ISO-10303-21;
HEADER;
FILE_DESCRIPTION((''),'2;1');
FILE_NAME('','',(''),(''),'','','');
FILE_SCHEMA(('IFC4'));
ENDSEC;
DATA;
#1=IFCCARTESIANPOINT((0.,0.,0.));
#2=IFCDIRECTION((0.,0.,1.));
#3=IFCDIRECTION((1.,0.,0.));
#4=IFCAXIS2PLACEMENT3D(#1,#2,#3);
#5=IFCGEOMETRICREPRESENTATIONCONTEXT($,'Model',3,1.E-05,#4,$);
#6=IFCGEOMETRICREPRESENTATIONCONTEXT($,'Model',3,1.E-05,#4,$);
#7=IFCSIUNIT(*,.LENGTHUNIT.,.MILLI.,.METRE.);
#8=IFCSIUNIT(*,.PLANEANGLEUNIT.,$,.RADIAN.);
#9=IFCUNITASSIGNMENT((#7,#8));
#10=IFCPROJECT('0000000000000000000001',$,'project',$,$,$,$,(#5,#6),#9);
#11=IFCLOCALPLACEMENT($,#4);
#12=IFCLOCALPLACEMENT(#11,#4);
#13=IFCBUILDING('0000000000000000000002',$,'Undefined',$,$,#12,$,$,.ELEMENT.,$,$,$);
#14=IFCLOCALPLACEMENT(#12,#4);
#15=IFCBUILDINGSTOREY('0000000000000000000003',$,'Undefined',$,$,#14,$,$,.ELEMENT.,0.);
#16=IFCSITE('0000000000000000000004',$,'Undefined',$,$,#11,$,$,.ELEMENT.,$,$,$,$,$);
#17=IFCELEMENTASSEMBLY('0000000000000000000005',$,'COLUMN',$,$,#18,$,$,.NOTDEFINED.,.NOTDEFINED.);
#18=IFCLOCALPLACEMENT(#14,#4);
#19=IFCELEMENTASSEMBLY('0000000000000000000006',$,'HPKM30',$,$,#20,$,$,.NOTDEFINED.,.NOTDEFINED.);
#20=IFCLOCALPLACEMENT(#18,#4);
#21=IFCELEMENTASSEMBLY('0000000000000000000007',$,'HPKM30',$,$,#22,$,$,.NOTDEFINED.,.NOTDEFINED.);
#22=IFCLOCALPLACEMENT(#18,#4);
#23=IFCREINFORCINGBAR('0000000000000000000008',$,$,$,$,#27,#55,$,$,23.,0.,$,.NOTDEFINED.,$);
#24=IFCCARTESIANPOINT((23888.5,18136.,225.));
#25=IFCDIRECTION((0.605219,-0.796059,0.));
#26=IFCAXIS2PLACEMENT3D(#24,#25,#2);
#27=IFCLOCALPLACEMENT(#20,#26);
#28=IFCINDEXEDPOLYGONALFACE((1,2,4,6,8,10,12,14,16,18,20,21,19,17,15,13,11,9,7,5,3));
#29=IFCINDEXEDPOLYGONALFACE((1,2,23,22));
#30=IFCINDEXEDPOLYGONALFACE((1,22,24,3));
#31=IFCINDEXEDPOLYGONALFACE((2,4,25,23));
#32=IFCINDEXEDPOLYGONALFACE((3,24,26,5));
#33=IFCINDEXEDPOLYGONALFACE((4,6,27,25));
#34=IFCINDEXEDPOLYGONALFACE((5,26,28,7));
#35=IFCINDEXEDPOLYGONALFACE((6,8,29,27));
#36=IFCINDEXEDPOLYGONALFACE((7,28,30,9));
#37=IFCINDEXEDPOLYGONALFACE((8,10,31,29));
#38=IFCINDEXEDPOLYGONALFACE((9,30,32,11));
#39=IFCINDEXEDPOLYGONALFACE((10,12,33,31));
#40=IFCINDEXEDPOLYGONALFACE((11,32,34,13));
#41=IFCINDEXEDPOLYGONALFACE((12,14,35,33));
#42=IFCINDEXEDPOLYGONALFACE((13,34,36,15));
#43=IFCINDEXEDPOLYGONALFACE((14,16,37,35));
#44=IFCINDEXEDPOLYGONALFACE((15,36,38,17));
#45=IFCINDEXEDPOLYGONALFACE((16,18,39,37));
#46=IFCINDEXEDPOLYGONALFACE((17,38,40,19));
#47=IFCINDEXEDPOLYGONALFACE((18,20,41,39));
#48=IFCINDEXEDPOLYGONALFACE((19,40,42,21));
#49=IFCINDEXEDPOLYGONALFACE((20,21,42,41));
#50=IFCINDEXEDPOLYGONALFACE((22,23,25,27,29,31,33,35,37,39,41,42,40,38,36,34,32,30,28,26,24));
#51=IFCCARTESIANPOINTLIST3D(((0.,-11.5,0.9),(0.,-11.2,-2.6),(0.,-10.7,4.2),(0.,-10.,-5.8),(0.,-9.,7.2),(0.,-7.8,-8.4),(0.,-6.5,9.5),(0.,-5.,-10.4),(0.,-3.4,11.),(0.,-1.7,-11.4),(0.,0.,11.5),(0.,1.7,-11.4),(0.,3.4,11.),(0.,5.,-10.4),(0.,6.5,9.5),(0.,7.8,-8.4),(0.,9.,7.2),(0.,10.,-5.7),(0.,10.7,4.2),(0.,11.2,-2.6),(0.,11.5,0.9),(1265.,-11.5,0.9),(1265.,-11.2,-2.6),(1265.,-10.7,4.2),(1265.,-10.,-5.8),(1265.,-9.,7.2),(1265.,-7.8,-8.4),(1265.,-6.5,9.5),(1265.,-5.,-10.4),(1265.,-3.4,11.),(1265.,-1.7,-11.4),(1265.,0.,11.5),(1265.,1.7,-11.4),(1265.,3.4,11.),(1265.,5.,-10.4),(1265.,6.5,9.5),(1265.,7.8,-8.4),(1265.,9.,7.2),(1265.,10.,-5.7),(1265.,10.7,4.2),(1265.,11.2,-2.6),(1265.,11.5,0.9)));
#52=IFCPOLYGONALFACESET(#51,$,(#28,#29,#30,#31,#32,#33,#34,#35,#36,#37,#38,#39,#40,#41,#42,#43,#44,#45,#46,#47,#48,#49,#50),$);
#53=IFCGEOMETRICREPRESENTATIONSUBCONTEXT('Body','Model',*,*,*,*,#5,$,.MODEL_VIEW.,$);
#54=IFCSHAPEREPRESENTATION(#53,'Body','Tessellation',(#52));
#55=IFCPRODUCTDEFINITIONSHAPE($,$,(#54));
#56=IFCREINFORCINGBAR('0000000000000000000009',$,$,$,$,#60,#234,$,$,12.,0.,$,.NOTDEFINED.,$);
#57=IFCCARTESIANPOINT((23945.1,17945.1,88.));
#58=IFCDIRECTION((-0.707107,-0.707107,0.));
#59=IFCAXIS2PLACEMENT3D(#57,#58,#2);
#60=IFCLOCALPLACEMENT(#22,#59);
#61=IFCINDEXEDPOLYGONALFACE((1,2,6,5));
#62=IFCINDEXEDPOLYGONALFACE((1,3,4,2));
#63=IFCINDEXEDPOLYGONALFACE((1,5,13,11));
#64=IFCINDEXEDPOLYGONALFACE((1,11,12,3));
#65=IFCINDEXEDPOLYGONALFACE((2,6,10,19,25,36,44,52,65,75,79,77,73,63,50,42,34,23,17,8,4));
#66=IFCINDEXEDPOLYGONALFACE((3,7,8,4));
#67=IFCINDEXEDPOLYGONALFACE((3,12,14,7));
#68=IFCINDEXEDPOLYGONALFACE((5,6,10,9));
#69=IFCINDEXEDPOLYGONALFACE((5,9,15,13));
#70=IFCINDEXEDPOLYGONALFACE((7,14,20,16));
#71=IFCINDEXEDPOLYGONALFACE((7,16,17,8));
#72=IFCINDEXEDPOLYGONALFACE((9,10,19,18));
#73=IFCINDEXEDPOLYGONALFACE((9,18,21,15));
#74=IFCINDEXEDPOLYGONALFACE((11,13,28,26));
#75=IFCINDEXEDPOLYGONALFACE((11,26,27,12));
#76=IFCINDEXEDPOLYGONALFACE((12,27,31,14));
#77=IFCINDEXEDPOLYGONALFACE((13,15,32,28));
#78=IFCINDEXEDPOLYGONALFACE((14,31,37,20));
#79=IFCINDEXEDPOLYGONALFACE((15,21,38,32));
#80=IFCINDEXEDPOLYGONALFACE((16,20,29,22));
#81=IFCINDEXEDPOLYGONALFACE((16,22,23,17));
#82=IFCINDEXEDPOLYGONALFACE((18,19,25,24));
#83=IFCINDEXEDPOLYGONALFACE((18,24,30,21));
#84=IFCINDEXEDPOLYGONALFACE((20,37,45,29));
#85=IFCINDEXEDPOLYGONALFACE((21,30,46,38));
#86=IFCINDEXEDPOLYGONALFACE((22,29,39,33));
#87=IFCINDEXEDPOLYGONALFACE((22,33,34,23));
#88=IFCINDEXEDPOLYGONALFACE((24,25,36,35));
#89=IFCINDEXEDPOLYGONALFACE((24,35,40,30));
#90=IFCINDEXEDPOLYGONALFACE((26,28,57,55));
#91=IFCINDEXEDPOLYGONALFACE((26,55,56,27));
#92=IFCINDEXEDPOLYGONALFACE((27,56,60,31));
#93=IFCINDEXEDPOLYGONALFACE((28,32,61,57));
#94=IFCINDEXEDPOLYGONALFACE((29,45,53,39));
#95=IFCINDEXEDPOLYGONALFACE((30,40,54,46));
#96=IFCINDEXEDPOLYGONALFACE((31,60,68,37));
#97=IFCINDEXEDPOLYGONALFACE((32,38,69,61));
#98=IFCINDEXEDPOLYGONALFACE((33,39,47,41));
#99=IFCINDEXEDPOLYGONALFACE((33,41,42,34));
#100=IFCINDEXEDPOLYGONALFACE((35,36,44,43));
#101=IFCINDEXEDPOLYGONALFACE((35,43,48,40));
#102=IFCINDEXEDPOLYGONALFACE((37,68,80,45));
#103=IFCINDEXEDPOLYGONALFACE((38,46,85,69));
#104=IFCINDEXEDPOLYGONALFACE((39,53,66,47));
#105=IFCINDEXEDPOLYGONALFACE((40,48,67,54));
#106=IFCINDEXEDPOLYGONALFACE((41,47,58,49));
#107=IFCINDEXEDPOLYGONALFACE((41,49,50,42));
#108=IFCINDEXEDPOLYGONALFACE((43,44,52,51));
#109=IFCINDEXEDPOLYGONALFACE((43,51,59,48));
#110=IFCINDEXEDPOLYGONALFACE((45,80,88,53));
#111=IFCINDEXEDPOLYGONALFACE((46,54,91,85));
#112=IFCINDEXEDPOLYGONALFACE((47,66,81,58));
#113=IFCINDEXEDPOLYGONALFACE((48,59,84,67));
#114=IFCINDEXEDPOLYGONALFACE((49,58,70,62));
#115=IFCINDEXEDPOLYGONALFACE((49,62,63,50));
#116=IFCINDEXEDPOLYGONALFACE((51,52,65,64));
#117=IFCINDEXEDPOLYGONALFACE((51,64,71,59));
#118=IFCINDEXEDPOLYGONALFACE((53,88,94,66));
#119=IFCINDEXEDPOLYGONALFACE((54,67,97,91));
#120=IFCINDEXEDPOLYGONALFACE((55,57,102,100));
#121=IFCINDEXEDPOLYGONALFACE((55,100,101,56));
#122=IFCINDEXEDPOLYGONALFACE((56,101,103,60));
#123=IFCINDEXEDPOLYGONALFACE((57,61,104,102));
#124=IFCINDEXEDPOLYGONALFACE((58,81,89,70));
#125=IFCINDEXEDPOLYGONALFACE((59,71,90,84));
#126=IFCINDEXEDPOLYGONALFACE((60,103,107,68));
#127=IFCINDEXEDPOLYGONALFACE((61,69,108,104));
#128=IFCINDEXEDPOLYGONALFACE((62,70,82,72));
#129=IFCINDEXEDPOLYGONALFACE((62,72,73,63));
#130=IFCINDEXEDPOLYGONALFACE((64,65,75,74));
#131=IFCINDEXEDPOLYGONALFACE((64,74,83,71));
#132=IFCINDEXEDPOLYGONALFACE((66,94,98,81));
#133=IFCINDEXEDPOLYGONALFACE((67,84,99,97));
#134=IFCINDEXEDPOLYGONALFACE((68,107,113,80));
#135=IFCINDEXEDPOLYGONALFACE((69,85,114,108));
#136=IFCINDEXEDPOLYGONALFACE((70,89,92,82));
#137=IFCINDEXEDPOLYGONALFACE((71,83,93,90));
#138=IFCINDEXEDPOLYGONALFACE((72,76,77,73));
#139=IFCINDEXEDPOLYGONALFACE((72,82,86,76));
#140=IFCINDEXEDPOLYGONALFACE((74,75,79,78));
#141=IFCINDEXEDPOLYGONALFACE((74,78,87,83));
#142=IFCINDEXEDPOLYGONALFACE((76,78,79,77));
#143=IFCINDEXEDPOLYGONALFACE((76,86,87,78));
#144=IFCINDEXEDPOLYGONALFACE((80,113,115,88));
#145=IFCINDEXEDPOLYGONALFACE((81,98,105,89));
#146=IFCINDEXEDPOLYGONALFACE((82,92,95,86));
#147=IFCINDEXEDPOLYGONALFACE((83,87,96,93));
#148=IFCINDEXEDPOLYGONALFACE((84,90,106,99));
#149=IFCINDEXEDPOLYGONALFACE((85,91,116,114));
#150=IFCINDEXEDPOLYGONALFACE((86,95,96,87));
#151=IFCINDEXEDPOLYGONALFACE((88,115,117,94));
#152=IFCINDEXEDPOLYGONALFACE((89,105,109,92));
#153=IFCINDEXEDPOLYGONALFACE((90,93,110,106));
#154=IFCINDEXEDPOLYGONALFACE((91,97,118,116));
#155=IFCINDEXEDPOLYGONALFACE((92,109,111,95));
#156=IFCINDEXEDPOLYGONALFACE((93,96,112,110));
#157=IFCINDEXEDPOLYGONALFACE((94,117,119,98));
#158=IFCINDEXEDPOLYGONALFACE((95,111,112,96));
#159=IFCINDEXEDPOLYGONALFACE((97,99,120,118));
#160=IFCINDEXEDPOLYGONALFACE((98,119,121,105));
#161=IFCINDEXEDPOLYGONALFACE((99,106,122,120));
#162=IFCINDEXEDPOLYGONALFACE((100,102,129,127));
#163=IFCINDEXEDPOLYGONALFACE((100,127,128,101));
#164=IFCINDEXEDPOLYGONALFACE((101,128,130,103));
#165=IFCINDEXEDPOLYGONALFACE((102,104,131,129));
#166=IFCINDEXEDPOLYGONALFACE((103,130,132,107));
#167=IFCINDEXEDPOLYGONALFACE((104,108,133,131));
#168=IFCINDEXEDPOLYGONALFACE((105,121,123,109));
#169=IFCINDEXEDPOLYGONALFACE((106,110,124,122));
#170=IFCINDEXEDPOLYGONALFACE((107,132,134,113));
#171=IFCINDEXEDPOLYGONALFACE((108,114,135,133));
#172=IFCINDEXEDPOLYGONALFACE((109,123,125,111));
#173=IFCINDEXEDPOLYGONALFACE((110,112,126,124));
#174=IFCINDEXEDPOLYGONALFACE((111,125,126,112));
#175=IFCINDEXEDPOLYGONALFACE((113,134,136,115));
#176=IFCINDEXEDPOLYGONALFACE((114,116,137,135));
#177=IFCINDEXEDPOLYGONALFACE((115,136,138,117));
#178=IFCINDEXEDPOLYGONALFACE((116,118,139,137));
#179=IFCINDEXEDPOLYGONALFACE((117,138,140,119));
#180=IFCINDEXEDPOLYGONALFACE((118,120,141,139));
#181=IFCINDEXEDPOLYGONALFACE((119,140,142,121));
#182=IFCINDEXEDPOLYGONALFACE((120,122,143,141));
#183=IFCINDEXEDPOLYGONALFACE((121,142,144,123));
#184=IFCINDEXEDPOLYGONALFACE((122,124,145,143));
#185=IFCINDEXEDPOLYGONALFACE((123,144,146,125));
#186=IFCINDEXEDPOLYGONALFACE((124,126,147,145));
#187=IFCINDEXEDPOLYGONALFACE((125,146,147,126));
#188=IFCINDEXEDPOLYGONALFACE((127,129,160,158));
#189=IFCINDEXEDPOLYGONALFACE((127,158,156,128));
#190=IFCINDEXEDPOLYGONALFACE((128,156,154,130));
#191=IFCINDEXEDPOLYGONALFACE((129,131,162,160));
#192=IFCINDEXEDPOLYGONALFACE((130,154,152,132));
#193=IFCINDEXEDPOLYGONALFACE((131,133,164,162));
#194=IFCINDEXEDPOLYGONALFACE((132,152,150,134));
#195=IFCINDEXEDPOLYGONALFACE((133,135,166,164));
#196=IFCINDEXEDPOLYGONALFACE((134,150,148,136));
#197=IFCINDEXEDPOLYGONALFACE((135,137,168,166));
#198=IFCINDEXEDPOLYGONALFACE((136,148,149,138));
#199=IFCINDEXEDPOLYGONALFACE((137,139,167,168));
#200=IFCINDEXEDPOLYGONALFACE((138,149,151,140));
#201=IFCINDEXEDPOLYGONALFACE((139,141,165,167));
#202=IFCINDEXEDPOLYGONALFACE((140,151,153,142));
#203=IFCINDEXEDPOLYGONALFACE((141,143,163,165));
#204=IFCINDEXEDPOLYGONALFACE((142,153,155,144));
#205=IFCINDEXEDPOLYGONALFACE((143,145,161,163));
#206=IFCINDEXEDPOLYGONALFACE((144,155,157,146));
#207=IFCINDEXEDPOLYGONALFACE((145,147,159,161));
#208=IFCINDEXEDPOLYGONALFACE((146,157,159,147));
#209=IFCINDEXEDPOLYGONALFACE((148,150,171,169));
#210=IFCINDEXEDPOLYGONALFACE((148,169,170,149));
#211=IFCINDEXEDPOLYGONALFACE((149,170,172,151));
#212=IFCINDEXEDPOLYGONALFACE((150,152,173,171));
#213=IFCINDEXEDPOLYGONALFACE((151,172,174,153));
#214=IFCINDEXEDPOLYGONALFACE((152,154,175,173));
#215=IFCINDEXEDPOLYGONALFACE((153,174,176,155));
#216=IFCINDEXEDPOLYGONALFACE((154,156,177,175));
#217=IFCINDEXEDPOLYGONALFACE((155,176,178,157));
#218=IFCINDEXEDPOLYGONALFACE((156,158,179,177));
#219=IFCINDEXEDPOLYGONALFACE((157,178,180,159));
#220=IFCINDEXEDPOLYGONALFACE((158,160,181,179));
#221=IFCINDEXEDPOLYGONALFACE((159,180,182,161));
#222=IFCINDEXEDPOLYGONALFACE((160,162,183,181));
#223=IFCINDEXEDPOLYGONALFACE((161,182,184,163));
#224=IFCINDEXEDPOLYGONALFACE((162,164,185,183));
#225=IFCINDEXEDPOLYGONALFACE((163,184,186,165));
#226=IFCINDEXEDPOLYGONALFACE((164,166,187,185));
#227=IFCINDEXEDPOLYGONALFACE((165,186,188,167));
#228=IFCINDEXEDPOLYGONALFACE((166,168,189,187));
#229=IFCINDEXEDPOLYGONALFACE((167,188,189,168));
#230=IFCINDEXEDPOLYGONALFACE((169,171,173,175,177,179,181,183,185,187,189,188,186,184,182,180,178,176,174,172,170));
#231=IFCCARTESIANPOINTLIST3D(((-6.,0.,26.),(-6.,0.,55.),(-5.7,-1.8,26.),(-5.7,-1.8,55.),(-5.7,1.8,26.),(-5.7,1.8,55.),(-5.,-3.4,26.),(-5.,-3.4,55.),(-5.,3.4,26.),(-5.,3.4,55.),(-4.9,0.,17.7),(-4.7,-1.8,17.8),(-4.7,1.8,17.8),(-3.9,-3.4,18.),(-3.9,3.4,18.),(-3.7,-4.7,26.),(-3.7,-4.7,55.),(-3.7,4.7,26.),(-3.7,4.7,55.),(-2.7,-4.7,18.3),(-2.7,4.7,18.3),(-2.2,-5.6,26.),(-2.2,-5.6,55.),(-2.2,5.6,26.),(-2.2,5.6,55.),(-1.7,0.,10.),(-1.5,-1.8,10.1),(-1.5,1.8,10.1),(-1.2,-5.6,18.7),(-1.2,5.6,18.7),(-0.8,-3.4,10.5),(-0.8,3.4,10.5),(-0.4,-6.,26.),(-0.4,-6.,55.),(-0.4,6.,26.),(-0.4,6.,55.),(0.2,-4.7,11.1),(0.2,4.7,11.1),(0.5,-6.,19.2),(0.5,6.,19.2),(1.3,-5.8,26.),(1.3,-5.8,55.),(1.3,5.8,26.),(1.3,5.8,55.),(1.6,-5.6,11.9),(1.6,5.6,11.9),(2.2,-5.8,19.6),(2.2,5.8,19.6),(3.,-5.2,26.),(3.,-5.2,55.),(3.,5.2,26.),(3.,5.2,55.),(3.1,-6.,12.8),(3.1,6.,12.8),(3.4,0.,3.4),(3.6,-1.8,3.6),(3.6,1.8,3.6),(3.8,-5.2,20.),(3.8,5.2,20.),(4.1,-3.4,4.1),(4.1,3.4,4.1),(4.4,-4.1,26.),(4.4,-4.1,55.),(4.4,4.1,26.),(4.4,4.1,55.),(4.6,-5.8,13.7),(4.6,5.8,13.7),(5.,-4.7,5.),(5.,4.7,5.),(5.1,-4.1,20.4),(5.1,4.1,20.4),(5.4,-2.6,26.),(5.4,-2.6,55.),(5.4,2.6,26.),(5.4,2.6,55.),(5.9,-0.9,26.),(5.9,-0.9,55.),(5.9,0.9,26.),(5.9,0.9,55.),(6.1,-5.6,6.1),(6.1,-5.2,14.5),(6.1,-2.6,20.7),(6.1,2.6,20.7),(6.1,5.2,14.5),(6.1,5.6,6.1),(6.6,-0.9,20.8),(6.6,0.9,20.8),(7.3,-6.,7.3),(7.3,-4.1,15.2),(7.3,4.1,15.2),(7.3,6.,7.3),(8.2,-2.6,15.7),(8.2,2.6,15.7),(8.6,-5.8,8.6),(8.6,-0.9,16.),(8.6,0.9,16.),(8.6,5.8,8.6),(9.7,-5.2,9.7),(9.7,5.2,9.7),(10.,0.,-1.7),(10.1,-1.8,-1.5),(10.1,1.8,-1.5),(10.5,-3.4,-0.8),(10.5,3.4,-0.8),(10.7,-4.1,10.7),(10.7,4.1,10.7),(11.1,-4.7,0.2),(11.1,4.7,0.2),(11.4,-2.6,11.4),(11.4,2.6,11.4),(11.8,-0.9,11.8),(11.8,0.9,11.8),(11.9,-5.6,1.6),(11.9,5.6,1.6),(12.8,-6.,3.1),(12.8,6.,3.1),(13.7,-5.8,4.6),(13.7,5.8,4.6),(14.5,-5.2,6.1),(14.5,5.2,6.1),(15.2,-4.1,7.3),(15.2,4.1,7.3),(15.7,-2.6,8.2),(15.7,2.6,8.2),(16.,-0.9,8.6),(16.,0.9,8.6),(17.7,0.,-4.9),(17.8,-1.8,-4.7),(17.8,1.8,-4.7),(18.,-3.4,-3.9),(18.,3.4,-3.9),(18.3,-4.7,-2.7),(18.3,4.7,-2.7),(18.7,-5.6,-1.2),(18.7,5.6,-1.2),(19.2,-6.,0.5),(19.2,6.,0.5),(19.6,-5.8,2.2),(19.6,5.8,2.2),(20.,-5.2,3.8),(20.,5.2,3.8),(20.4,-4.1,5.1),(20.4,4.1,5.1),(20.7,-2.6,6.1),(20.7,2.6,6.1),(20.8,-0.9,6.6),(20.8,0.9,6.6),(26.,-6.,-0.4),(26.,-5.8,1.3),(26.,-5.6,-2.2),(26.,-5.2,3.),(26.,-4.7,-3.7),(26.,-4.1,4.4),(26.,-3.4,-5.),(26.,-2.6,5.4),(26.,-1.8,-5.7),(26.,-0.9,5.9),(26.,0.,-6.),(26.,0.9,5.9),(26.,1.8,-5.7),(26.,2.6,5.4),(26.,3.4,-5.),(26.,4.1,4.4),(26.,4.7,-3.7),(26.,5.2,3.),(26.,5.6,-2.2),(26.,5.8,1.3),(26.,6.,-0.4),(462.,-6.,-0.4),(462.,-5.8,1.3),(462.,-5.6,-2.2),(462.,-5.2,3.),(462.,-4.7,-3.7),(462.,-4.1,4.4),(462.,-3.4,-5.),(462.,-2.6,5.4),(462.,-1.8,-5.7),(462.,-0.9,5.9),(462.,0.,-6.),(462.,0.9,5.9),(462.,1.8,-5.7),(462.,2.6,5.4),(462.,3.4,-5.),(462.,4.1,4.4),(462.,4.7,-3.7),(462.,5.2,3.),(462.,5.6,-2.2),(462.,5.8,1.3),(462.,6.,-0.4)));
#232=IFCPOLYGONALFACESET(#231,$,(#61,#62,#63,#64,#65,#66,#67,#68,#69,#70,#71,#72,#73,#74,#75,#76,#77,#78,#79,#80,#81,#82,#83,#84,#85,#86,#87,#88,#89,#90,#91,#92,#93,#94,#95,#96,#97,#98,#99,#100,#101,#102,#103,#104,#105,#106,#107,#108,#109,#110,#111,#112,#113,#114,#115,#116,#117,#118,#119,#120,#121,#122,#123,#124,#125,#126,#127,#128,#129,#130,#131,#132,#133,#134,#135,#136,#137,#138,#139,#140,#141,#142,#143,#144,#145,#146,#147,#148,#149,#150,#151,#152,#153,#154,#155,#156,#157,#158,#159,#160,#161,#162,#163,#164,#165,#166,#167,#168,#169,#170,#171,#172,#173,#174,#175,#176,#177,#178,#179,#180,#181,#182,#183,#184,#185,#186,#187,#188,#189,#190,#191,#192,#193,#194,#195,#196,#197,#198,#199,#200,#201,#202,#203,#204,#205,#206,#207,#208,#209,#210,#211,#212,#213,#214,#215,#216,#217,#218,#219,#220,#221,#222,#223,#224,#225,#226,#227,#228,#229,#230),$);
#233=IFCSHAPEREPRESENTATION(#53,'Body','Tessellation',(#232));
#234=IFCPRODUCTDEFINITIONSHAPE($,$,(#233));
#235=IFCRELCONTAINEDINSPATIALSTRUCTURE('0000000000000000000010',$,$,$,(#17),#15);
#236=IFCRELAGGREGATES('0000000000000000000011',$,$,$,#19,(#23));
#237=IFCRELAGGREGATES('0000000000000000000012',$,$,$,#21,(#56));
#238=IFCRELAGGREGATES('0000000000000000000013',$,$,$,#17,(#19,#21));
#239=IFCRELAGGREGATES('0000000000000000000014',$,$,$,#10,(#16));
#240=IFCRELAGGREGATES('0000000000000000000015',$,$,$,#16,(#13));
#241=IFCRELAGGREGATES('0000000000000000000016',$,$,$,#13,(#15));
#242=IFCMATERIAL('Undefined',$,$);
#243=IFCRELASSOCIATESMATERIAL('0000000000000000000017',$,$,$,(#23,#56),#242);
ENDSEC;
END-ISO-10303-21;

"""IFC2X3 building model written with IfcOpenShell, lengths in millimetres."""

from ifc_helpers import new_model, entity, si_unit, frame, origin_with_axes, place, context, subcontext, project, spatial, source, transform, mapped, material, element, aggregate, save


model = new_model("IFC2X3")

# Units and contexts
model_context_1 = context("Model", 3, precision=1e-05, world=origin_with_axes())
model_context_2 = context("Model", 3, precision=1e-05, world=origin_with_axes())
body_context = subcontext(model_context_1, "Body", "Model", "MODEL_VIEW")
ifc_project = project(units=[si_unit("LENGTHUNIT", "METRE", prefix="MILLI"), si_unit("PLANEANGLEUNIT", "RADIAN")], contexts=[model_context_1, model_context_2])

# Site, building, storey
site_placement = place(None, origin_with_axes())
site = spatial("IfcSite", under=ifc_project, at=site_placement, Name="Undefined", CompositionType="ELEMENT")
building_placement = place(site_placement, origin_with_axes())
building = spatial("IfcBuilding", under=site, at=building_placement, Name="Undefined", CompositionType="ELEMENT")
storey_placement = place(building_placement, origin_with_axes())
storey = spatial("IfcBuildingStorey", under=building, at=storey_placement, Name="Undefined", CompositionType="ELEMENT", Elevation=0.0)

# Element assemblies
assembly_1_placement = place(storey_placement, origin_with_axes())
assembly_1 = element("IfcElementAssembly", 1, at=assembly_1_placement, inside=storey, Name="COLUMN", AssemblyPlace="NOTDEFINED", PredefinedType="NOTDEFINED")
assembly_2_placement = place(assembly_1_placement, origin_with_axes())
assembly_2 = element("IfcElementAssembly", 2, at=assembly_2_placement, Name="HPKM30", AssemblyPlace="NOTDEFINED", PredefinedType="NOTDEFINED")
assembly_3_placement = place(assembly_1_placement, origin_with_axes())
assembly_3 = element("IfcElementAssembly", 3, at=assembly_3_placement, Name="HPKM30", AssemblyPlace="NOTDEFINED", PredefinedType="NOTDEFINED")
ifc_material_1 = material(Name="Undefined")

# Reinforcing bars
shared_shape_1 = source(origin_with_axes(), body_context, "Body", "AdvancedSweptSolid", [
    entity("IfcSweptDiskSolid", entity("IfcTrimmedCurve", entity("IfcLine", entity("IfcCartesianPoint", [0.0, 0.0, 0.0]), entity("IfcVector", entity("IfcDirection", [1.0, 0.0, 0.0]), 1.0)), [entity("IfcParameterValue", 0.0)], [entity("IfcParameterValue", 1265.0)], True, "PARAMETER"), 11.5, None, 0.0, 1265.0),
])
reinforcing_bar_1_placement = place(assembly_2_placement, frame((23888.5, 18136.0, 225.0), z_axis=(0.605219, -0.796059, 0.0), x_axis=(0.0, 0.0, 1.0)))
reinforcing_bar_1 = element("IfcReinforcingBar", 4, at=reinforcing_bar_1_placement, material=ifc_material_1, BarRole="NOTDEFINED", CrossSectionArea=0.0, NominalDiameter=23.0, context=body_context, shape_type="MappedRepresentation", body=[
    mapped(shared_shape_1, transform((0.0, 0.0, 0.0))),
])
aggregate(assembly_2, [reinforcing_bar_1])
shared_shape_2 = source(origin_with_axes(), body_context, "Body", "AdvancedSweptSolid", [
    entity("IfcSweptDiskSolid", entity("IfcCompositeCurve", [entity("IfcCompositeCurveSegment", "CONTINUOUS", True, entity("IfcTrimmedCurve", entity("IfcLine", entity("IfcCartesianPoint", [0.0, 0.0, 0.0]), entity("IfcVector", entity("IfcDirection", [0.0, 0.0, -1.0]), 1.0)), [entity("IfcParameterValue", 0.0)], [entity("IfcParameterValue", 29.0)], True, "PARAMETER")), entity("IfcCompositeCurveSegment", "CONTINUOUS", True, entity("IfcTrimmedCurve", entity("IfcCircle", entity("IfcAxis2Placement3D", entity("IfcCartesianPoint", [26.0, 0.0, -29.0]), entity("IfcDirection", [0.0, -1.0, 0.0]), entity("IfcDirection", [-1.0, 0.0, 0.0])), 26.0), [entity("IfcParameterValue", 0.0)], [entity("IfcParameterValue", 1.570796)], True, "PARAMETER")), entity("IfcCompositeCurveSegment", "DISCONTINUOUS", True, entity("IfcTrimmedCurve", entity("IfcLine", entity("IfcCartesianPoint", [26.0, 0.0, -55.0]), entity("IfcVector", entity("IfcDirection", [1.0, 0.0, 0.0]), 1.0)), [entity("IfcParameterValue", 0.0)], [entity("IfcParameterValue", 436.0)], True, "PARAMETER"))], False), 6.0, None, 0.0, 466.6),
])
reinforcing_bar_2_placement = place(assembly_3_placement, frame((23945.1, 17945.1, 88.0), z_axis=(-0.707107, -0.707107, 0.0), x_axis=(0.0, 0.0, 1.0)))
reinforcing_bar_2 = element("IfcReinforcingBar", 5, at=reinforcing_bar_2_placement, material=ifc_material_1, BarRole="NOTDEFINED", CrossSectionArea=0.0, NominalDiameter=12.0, context=body_context, shape_type="MappedRepresentation", body=[
    mapped(shared_shape_2, transform((0.0, 0.0, 55.0))),
])
aggregate(assembly_3, [reinforcing_bar_2])
aggregate(assembly_1, [assembly_2, assembly_3])

save(model, "model.ifc")
